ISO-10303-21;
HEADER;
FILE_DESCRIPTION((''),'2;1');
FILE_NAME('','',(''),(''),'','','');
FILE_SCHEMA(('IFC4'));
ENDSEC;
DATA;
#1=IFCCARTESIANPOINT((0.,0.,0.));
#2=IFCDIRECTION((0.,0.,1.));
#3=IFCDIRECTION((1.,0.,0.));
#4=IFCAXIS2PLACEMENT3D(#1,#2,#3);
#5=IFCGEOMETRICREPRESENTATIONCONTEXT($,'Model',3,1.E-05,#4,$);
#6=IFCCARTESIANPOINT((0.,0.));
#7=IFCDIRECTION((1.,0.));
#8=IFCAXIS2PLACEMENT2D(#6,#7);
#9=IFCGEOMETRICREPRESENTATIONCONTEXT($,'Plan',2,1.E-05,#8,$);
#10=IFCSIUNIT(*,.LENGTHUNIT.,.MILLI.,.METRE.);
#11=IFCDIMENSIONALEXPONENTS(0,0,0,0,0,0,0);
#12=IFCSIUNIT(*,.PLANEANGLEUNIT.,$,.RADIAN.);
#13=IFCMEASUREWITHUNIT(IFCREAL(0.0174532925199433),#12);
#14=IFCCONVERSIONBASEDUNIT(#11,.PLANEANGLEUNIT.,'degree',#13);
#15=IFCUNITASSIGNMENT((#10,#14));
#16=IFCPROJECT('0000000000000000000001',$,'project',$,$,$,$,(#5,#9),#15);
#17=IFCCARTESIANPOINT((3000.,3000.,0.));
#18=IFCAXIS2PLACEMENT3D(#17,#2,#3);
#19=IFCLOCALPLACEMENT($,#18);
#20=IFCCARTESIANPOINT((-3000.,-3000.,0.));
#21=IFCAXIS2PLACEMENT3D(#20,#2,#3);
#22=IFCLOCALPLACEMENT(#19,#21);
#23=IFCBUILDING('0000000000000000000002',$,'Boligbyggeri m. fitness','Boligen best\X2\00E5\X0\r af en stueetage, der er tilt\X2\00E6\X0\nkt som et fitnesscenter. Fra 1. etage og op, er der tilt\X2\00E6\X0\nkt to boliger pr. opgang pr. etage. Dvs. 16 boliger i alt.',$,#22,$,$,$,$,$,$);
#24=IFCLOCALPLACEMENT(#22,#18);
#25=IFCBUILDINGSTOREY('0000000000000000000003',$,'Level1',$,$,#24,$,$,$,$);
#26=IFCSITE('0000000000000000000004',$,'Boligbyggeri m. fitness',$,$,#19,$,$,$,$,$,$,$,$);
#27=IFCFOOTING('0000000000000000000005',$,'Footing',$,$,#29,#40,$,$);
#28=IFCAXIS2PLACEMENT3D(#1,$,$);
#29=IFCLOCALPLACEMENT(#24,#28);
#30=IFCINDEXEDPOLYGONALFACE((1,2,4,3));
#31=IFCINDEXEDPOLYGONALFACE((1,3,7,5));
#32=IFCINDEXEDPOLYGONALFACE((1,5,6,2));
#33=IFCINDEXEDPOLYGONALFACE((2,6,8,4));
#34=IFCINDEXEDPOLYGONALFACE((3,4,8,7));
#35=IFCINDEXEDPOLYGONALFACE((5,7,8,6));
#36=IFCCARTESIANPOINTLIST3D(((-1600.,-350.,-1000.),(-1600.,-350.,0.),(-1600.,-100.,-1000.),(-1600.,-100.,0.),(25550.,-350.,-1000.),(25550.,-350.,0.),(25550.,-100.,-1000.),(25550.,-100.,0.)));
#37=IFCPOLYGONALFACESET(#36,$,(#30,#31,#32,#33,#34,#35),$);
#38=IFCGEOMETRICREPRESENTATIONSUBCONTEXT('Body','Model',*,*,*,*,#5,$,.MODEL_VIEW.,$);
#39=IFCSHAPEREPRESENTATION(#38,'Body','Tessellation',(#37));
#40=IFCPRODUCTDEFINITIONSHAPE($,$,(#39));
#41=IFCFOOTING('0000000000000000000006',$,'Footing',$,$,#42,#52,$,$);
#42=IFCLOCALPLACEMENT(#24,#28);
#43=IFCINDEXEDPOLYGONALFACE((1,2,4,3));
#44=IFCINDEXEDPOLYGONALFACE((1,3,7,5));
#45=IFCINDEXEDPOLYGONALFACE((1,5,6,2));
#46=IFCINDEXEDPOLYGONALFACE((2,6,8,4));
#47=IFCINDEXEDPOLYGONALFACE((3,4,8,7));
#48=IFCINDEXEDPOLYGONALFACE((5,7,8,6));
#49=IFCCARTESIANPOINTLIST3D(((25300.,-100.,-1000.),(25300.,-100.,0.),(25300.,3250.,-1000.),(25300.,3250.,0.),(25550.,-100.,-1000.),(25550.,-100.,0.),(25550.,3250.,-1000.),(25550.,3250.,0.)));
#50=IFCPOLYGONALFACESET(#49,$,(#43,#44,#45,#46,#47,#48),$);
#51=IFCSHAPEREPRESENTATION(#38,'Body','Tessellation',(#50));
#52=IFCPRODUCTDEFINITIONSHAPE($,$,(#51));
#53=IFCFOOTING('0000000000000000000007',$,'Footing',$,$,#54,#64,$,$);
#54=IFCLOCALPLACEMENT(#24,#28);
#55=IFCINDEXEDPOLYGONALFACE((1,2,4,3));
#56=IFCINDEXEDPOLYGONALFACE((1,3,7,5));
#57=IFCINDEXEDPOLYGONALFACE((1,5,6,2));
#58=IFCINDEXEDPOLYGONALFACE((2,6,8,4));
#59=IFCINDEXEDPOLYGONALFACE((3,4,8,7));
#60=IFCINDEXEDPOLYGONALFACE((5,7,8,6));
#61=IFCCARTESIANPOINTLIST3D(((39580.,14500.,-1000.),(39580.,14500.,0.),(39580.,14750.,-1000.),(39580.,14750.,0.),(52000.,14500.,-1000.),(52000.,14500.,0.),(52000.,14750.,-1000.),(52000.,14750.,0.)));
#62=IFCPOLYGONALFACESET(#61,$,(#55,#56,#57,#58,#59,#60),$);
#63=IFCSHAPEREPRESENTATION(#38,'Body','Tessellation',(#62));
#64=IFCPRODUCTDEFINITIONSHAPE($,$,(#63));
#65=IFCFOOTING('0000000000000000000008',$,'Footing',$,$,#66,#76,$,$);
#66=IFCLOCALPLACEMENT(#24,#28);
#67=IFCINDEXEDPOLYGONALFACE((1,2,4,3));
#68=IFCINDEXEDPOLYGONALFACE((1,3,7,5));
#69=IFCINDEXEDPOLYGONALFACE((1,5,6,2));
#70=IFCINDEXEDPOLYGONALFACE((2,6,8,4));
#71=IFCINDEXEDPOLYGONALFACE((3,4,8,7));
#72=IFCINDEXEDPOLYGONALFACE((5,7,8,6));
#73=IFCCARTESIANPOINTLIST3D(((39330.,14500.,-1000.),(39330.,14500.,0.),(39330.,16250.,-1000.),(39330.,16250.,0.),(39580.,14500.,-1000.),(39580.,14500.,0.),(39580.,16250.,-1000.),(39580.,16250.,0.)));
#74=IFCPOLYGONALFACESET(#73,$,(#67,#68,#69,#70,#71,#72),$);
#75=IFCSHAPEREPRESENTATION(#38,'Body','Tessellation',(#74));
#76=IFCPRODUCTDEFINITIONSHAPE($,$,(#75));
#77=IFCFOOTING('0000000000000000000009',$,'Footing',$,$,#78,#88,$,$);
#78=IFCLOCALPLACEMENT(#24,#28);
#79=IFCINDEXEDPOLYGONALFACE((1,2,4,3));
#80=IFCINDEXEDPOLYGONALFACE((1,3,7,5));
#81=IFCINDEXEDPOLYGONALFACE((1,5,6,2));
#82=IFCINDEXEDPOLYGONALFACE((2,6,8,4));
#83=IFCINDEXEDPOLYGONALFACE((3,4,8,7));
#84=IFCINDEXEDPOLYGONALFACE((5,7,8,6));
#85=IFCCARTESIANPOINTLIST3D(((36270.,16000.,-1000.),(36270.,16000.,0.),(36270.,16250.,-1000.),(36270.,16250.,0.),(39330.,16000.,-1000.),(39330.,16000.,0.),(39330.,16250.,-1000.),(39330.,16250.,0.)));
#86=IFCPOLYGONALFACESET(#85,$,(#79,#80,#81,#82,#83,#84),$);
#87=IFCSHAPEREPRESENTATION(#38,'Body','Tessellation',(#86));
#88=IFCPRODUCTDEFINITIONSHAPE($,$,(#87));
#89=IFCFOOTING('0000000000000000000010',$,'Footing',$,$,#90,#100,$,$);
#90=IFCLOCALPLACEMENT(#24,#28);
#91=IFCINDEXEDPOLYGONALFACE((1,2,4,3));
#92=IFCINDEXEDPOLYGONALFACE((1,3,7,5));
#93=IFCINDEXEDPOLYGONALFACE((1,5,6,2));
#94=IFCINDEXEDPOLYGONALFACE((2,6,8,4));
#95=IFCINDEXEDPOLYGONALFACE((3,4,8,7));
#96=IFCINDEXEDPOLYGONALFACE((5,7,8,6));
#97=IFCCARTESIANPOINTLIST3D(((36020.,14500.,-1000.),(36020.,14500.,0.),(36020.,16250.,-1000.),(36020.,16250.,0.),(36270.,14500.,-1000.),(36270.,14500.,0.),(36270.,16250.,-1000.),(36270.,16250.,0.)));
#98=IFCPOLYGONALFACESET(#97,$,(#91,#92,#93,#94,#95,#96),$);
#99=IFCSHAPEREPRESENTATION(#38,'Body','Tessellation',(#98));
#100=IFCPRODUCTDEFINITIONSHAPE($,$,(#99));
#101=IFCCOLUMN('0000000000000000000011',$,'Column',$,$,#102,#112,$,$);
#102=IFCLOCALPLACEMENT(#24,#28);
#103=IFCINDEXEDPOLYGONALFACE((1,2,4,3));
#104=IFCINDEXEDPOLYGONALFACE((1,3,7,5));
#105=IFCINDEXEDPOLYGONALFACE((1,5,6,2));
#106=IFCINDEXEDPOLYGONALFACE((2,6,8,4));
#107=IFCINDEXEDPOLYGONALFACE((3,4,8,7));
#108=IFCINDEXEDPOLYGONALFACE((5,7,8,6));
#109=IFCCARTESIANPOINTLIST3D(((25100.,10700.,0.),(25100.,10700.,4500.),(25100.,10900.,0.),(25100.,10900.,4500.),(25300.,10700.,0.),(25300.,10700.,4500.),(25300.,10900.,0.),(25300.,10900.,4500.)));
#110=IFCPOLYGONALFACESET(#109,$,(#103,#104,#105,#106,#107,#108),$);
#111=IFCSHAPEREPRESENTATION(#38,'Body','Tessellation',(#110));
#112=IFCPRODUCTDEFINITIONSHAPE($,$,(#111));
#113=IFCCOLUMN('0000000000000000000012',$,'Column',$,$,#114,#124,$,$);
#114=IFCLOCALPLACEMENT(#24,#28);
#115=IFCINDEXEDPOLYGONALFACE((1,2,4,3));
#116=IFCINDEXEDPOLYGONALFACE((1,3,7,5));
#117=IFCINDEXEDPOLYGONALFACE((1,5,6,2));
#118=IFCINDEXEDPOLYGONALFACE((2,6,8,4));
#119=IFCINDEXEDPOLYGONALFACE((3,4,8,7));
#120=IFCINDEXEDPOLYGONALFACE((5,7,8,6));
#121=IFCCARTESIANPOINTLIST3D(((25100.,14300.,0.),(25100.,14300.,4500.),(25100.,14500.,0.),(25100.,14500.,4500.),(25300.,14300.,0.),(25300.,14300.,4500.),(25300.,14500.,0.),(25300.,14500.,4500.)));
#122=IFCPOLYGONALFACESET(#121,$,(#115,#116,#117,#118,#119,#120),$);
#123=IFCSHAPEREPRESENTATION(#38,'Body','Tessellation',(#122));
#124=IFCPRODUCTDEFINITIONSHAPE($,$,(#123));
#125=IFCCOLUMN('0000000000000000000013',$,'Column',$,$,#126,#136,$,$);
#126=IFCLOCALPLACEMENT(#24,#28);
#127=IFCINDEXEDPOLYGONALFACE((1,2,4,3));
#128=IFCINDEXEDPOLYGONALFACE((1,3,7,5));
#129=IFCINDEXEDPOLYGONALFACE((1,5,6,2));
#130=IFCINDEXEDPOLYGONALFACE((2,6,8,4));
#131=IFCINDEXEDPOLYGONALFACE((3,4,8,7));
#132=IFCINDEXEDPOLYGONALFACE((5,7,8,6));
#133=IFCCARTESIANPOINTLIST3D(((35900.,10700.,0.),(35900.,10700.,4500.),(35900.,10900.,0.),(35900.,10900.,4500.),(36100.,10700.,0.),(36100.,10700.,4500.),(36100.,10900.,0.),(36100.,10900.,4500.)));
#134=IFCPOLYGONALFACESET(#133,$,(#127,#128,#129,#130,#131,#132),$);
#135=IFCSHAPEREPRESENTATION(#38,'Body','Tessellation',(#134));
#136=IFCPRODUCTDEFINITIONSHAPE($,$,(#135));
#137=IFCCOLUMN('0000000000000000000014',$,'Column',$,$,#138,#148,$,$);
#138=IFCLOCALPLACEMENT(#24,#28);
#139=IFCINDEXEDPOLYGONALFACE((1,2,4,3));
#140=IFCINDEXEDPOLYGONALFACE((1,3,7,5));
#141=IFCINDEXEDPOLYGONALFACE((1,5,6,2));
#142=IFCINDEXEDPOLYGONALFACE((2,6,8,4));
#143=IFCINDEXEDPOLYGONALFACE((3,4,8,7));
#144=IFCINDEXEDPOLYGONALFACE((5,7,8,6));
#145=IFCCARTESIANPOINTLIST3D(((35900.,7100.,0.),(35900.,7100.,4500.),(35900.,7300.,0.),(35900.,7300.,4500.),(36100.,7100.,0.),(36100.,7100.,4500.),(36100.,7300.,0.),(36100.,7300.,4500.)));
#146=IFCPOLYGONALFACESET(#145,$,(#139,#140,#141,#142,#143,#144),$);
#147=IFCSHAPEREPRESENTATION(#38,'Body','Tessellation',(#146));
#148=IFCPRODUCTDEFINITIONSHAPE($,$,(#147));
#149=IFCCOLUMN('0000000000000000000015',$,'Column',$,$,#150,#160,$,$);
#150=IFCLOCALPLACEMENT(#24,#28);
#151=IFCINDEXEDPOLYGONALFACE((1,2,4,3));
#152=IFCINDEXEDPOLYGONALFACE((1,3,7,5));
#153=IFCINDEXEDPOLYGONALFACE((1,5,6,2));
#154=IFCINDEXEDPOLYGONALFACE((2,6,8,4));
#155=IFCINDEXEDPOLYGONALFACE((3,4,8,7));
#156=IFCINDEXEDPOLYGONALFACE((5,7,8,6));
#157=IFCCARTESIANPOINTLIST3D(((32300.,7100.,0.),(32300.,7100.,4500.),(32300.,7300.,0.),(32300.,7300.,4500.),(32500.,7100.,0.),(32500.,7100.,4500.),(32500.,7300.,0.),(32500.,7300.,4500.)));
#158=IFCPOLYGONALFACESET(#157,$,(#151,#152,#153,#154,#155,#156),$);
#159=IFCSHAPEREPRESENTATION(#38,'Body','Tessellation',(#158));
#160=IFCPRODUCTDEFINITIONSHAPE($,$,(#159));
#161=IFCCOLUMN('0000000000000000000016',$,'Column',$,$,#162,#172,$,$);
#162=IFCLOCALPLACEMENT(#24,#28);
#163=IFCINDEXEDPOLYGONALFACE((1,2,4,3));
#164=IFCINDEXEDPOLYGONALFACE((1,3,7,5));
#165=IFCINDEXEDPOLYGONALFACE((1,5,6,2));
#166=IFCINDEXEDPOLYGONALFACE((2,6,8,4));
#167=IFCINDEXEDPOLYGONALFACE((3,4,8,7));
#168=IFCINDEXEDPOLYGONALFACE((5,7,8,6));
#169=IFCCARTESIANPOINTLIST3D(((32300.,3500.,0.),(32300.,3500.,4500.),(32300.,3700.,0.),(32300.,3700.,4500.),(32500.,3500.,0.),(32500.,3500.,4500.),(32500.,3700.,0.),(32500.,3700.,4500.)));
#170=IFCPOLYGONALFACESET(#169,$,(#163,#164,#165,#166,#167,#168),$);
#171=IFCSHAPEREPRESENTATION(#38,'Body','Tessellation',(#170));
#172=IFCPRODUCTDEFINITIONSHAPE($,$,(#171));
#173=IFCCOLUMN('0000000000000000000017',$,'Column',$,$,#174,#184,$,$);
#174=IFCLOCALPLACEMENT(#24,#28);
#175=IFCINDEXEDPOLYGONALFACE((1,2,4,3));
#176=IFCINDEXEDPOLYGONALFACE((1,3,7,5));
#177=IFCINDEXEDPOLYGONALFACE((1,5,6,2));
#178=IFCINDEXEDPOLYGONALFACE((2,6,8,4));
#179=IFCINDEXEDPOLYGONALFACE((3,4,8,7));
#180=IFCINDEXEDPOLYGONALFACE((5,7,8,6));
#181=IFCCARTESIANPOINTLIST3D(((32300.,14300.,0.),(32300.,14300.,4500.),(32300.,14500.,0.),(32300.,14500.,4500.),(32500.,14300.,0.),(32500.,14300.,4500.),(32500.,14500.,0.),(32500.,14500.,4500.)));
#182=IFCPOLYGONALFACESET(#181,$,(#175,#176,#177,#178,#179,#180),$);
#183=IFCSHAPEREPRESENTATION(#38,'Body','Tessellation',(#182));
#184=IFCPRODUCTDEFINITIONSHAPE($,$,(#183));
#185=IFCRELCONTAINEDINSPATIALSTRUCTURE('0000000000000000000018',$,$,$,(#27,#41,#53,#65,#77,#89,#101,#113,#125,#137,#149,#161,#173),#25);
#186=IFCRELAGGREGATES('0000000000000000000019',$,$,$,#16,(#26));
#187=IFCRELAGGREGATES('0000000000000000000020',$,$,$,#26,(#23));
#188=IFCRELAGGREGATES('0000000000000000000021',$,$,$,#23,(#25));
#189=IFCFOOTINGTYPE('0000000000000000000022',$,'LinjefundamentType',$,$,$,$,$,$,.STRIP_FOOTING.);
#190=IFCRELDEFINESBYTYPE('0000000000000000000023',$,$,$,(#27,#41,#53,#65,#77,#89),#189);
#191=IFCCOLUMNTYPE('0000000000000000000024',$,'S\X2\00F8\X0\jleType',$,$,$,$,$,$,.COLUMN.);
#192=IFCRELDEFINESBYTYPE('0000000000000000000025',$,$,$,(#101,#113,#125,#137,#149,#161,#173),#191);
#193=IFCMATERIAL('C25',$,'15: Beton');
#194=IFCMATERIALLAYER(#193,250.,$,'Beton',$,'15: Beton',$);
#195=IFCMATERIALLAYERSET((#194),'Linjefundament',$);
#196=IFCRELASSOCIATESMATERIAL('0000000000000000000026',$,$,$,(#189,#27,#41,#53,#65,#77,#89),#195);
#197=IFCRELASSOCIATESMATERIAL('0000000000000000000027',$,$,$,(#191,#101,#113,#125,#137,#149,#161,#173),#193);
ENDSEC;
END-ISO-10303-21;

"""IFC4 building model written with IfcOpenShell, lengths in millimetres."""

from ifc_helpers import new_model, entity, si_unit, converted_unit, frame, origin_with_axes, origin_2d_with_axis, place, context, subcontext, project, spatial, indexed_curve, rectangle, outline, extrude, material, layer, layer_set, layer_usage, material_profile, profile_set, profile_usage, type_object, element, save


model = new_model("IFC4")

# Units and contexts
model_context = context("Model", 3, precision=1e-05, world=origin_with_axes())
plan_context = context("Plan", 2, precision=1e-05, world=origin_2d_with_axis())
body_context = subcontext(model_context, "Body", "Model", "MODEL_VIEW")
ifc_project = project(units=[si_unit("LENGTHUNIT", "METRE", prefix="MILLI"), converted_unit("PLANEANGLEUNIT", "degree", entity("IfcReal", 0.0174532925199433), si_unit("PLANEANGLEUNIT", "RADIAN"), dimensions=[0, 0, 0, 0, 0, 0, 0])], contexts=[model_context, plan_context])

# Site, building, storey
site_placement = place(None, frame((3000.0, 3000.0, 0.0), z_axis=(0.0, 0.0, 1.0), x_axis=(1.0, 0.0, 0.0)))
site = spatial("IfcSite", under=ifc_project, at=site_placement, Name="Boligbyggeri m. fitness")
building_placement = place(site_placement, frame((-3000.0, -3000.0, 0.0), z_axis=(0.0, 0.0, 1.0), x_axis=(1.0, 0.0, 0.0)))
building = spatial("IfcBuilding", under=site, at=building_placement, Name="Boligbyggeri m. fitness", Description="Boligen består af en stueetage, der er tiltænkt som et fitnesscenter. Fra 1. etage og op, er der tiltænkt to boliger pr. opgang pr. etage. Dvs. 16 boliger i alt.")
storey_placement = place(building_placement, frame((3000.0, 3000.0, 0.0), z_axis=(0.0, 0.0, 1.0), x_axis=(1.0, 0.0, 0.0)))
storey = spatial("IfcBuildingStorey", under=building, at=storey_placement, Name="Level1")

# Footings
ifc_material_1 = material(Name="C25", Category="15: Beton")
ifc_layer_1 = layer(ifc_material_1, 250.0, Name="Beton", Category="15: Beton")
ifc_layer_set_1 = layer_set([ifc_layer_1], Name="Linjefundament")
ifc_layer_usage_1 = layer_usage(ifc_layer_set_1, "AXIS2", "POSITIVE", 0.0)
footing_type = type_object("IfcFootingType", Name="LinjefundamentType", PredefinedType="STRIP_FOOTING", material=ifc_layer_set_1)
footing_1_placement = place(storey_placement, frame((25550.0, -100.0, -1000.0), z_axis=(0.0, 0.0, 1.0), x_axis=(-1.0, 0.0, 0.0)))
element("IfcFooting", 1, at=footing_1_placement, inside=storey, type_object=footing_type, material=ifc_layer_usage_1, Name="Footing", context=body_context, shape_type="SweptSolid", body=[
    extrude(outline(indexed_curve([(0.0, 0.0), (0.0, 250.0), (27150.0, 250.0), (27150.0, 0.0), (0.0, 0.0)], self_intersect=False)), origin_with_axes(), (0.0, 0.0, 1.0), 1000.0),
])
ifc_layer_usage_2 = layer_usage(ifc_layer_set_1, "AXIS2", "POSITIVE", 0.0)
footing_2_placement = place(storey_placement, frame((25300.0, 3250.0, -1000.0), z_axis=(0.0, 0.0, 1.0), x_axis=(-0.000001, -1.0, 0.0)))
element("IfcFooting", 2, at=footing_2_placement, inside=storey, type_object=footing_type, material=ifc_layer_usage_2, Name="Footing", context=body_context, shape_type="SweptSolid", body=[
    extrude(outline(indexed_curve([(0.0, 0.0), (0.0, 250.0), (3350.0, 250.0), (3350.0, 0.0), (0.0, 0.0)], self_intersect=False)), origin_with_axes(), (0.0, 0.0, 1.0), 1000.0),
])
ifc_layer_usage_3 = layer_usage(ifc_layer_set_1, "AXIS2", "POSITIVE", 0.0)
footing_3_placement = place(storey_placement, frame((39580.0, 14500.0, -1000.0), z_axis=(0.0, 0.0, 1.0), x_axis=(1.0, 0.0, 0.0)))
element("IfcFooting", 3, at=footing_3_placement, inside=storey, type_object=footing_type, material=ifc_layer_usage_3, Name="Footing", context=body_context, shape_type="SweptSolid", body=[
    extrude(outline(indexed_curve([(0.0, 0.0), (0.0, 250.0), (12420.0, 250.0), (12420.0, 0.0), (0.0, 0.0)], self_intersect=False)), origin_with_axes(), (0.0, 0.0, 1.0), 1000.0),
])
ifc_layer_usage_4 = layer_usage(ifc_layer_set_1, "AXIS2", "POSITIVE", 0.0)
footing_4_placement = place(storey_placement, frame((39330.0, 16250.0, -1000.0), z_axis=(0.0, 0.0, 1.0), x_axis=(0.0, -1.0, 0.0)))
element("IfcFooting", 4, at=footing_4_placement, inside=storey, type_object=footing_type, material=ifc_layer_usage_4, Name="Footing", context=body_context, shape_type="SweptSolid", body=[
    extrude(outline(indexed_curve([(0.0, 0.0), (0.0, 250.0), (1750.0, 250.0), (1750.0, 0.0), (0.0, 0.0)], self_intersect=False)), origin_with_axes(), (0.0, 0.0, 1.0), 1000.0),
])
ifc_layer_usage_5 = layer_usage(ifc_layer_set_1, "AXIS2", "POSITIVE", 0.0)
footing_5_placement = place(storey_placement, frame((36270.0, 16000.0, -1000.0), z_axis=(0.0, 0.0, 1.0), x_axis=(1.0, 0.0, 0.0)))
element("IfcFooting", 5, at=footing_5_placement, inside=storey, type_object=footing_type, material=ifc_layer_usage_5, Name="Footing", context=body_context, shape_type="SweptSolid", body=[
    extrude(outline(indexed_curve([(0.0, 0.0), (0.0, 250.0), (3060.0, 250.0), (3060.0, 0.0), (0.0, 0.0)], self_intersect=False)), origin_with_axes(), (0.0, 0.0, 1.0), 1000.0),
])
ifc_layer_usage_6 = layer_usage(ifc_layer_set_1, "AXIS2", "POSITIVE", 0.0)
footing_6_placement = place(storey_placement, frame((36270.0, 14500.0, -1000.0), z_axis=(0.0, 0.0, 1.0), x_axis=(0.0, 1.0, 0.0)))
element("IfcFooting", 6, at=footing_6_placement, inside=storey, type_object=footing_type, material=ifc_layer_usage_6, Name="Footing", context=body_context, shape_type="SweptSolid", body=[
    extrude(outline(indexed_curve([(0.0, 0.0), (0.0, 250.0), (1750.0, 250.0), (1750.0, 0.0), (0.0, 0.0)], self_intersect=False)), origin_with_axes(), (0.0, 0.0, 1.0), 1000.0),
])

# Columns
ifc_material_profile_1 = material_profile(ifc_material_1, rectangle(XDim=200.0, YDim=200.0), Name="SøjleBeton", Category="15: Beton")
ifc_profile_set_1 = profile_set([ifc_material_profile_1], Name="200x200")
ifc_profile_usage_1 = profile_usage(ifc_profile_set_1, cardinal=5)
column_type = type_object("IfcColumnType", Name="SøjleType", PredefinedType="COLUMN", material=ifc_profile_set_1)
column_1_placement = place(storey_placement, frame((25200.0, 10800.0, 0.0), z_axis=(0.0, 0.0, 1.0), x_axis=(1.0, 0.0, 0.0)))
element("IfcColumn", 7, at=column_1_placement, inside=storey, type_object=column_type, material=ifc_profile_usage_1, Name="Column", context=body_context, shape_type="SweptSolid", body=[
    extrude(rectangle(XDim=200.0, YDim=200.0), origin_with_axes(), (0.0, 0.0, 1.0), 4500.0),
])
ifc_profile_usage_2 = profile_usage(ifc_profile_set_1, cardinal=2)
column_2_placement = place(storey_placement, frame((25200.0, 14300.0, 0.0), z_axis=(0.0, 0.0, 1.0), x_axis=(1.0, 0.0, 0.0)))
element("IfcColumn", 8, at=column_2_placement, inside=storey, type_object=column_type, material=ifc_profile_usage_2, Name="Column", context=body_context, shape_type="SweptSolid", body=[
    extrude(rectangle(XDim=200.0, YDim=200.0), frame((0.0, 100.0, 0.0), z_axis=(0.0, 0.0, 1.0), x_axis=(1.0, 0.0, 0.0)), (0.0, 0.0, 1.0), 4500.0),
])
ifc_profile_usage_3 = profile_usage(ifc_profile_set_1, cardinal=5)
column_3_placement = place(storey_placement, frame((36000.0, 10800.0, 0.0), z_axis=(0.0, 0.0, 1.0), x_axis=(1.0, 0.0, 0.0)))
element("IfcColumn", 9, at=column_3_placement, inside=storey, type_object=column_type, material=ifc_profile_usage_3, Name="Column", context=body_context, shape_type="SweptSolid", body=[
    extrude(rectangle(XDim=200.0, YDim=200.0), origin_with_axes(), (0.0, 0.0, 1.0), 4500.0),
])
ifc_profile_usage_4 = profile_usage(ifc_profile_set_1, cardinal=5)
column_4_placement = place(storey_placement, frame((36000.0, 7200.0, 0.0), z_axis=(0.0, 0.0, 1.0), x_axis=(1.0, 0.0, 0.0)))
element("IfcColumn", 10, at=column_4_placement, inside=storey, type_object=column_type, material=ifc_profile_usage_4, Name="Column", context=body_context, shape_type="SweptSolid", body=[
    extrude(rectangle(XDim=200.0, YDim=200.0), origin_with_axes(), (0.0, 0.0, 1.0), 4500.0),
])
ifc_profile_usage_5 = profile_usage(ifc_profile_set_1, cardinal=5)
column_5_placement = place(storey_placement, frame((32400.0, 7200.0, 0.0), z_axis=(0.0, 0.0, 1.0), x_axis=(1.0, 0.0, 0.0)))
element("IfcColumn", 11, at=column_5_placement, inside=storey, type_object=column_type, material=ifc_profile_usage_5, Name="Column", context=body_context, shape_type="SweptSolid", body=[
    extrude(rectangle(XDim=200.0, YDim=200.0), origin_with_axes(), (0.0, 0.0, 1.0), 4500.0),
])
ifc_profile_usage_6 = profile_usage(ifc_profile_set_1, cardinal=5)
column_6_placement = place(storey_placement, frame((32400.0, 3600.0, 0.0), z_axis=(0.0, 0.0, 1.0), x_axis=(1.0, 0.0, 0.0)))
element("IfcColumn", 12, at=column_6_placement, inside=storey, type_object=column_type, material=ifc_profile_usage_6, Name="Column", context=body_context, shape_type="SweptSolid", body=[
    extrude(rectangle(XDim=200.0, YDim=200.0), origin_with_axes(), (0.0, 0.0, 1.0), 4500.0),
])
ifc_profile_usage_7 = profile_usage(ifc_profile_set_1, cardinal=5)
column_7_placement = place(storey_placement, frame((32400.0, 14400.0, 0.0), z_axis=(0.0, 0.0, 1.0), x_axis=(1.0, 0.0, 0.0)))
element("IfcColumn", 13, at=column_7_placement, inside=storey, type_object=column_type, material=ifc_profile_usage_7, Name="Column", context=body_context, shape_type="SweptSolid", body=[
    extrude(rectangle(XDim=200.0, YDim=200.0), origin_with_axes(), (0.0, 0.0, 1.0), 4500.0),
])

save(model, "model.ifc")
